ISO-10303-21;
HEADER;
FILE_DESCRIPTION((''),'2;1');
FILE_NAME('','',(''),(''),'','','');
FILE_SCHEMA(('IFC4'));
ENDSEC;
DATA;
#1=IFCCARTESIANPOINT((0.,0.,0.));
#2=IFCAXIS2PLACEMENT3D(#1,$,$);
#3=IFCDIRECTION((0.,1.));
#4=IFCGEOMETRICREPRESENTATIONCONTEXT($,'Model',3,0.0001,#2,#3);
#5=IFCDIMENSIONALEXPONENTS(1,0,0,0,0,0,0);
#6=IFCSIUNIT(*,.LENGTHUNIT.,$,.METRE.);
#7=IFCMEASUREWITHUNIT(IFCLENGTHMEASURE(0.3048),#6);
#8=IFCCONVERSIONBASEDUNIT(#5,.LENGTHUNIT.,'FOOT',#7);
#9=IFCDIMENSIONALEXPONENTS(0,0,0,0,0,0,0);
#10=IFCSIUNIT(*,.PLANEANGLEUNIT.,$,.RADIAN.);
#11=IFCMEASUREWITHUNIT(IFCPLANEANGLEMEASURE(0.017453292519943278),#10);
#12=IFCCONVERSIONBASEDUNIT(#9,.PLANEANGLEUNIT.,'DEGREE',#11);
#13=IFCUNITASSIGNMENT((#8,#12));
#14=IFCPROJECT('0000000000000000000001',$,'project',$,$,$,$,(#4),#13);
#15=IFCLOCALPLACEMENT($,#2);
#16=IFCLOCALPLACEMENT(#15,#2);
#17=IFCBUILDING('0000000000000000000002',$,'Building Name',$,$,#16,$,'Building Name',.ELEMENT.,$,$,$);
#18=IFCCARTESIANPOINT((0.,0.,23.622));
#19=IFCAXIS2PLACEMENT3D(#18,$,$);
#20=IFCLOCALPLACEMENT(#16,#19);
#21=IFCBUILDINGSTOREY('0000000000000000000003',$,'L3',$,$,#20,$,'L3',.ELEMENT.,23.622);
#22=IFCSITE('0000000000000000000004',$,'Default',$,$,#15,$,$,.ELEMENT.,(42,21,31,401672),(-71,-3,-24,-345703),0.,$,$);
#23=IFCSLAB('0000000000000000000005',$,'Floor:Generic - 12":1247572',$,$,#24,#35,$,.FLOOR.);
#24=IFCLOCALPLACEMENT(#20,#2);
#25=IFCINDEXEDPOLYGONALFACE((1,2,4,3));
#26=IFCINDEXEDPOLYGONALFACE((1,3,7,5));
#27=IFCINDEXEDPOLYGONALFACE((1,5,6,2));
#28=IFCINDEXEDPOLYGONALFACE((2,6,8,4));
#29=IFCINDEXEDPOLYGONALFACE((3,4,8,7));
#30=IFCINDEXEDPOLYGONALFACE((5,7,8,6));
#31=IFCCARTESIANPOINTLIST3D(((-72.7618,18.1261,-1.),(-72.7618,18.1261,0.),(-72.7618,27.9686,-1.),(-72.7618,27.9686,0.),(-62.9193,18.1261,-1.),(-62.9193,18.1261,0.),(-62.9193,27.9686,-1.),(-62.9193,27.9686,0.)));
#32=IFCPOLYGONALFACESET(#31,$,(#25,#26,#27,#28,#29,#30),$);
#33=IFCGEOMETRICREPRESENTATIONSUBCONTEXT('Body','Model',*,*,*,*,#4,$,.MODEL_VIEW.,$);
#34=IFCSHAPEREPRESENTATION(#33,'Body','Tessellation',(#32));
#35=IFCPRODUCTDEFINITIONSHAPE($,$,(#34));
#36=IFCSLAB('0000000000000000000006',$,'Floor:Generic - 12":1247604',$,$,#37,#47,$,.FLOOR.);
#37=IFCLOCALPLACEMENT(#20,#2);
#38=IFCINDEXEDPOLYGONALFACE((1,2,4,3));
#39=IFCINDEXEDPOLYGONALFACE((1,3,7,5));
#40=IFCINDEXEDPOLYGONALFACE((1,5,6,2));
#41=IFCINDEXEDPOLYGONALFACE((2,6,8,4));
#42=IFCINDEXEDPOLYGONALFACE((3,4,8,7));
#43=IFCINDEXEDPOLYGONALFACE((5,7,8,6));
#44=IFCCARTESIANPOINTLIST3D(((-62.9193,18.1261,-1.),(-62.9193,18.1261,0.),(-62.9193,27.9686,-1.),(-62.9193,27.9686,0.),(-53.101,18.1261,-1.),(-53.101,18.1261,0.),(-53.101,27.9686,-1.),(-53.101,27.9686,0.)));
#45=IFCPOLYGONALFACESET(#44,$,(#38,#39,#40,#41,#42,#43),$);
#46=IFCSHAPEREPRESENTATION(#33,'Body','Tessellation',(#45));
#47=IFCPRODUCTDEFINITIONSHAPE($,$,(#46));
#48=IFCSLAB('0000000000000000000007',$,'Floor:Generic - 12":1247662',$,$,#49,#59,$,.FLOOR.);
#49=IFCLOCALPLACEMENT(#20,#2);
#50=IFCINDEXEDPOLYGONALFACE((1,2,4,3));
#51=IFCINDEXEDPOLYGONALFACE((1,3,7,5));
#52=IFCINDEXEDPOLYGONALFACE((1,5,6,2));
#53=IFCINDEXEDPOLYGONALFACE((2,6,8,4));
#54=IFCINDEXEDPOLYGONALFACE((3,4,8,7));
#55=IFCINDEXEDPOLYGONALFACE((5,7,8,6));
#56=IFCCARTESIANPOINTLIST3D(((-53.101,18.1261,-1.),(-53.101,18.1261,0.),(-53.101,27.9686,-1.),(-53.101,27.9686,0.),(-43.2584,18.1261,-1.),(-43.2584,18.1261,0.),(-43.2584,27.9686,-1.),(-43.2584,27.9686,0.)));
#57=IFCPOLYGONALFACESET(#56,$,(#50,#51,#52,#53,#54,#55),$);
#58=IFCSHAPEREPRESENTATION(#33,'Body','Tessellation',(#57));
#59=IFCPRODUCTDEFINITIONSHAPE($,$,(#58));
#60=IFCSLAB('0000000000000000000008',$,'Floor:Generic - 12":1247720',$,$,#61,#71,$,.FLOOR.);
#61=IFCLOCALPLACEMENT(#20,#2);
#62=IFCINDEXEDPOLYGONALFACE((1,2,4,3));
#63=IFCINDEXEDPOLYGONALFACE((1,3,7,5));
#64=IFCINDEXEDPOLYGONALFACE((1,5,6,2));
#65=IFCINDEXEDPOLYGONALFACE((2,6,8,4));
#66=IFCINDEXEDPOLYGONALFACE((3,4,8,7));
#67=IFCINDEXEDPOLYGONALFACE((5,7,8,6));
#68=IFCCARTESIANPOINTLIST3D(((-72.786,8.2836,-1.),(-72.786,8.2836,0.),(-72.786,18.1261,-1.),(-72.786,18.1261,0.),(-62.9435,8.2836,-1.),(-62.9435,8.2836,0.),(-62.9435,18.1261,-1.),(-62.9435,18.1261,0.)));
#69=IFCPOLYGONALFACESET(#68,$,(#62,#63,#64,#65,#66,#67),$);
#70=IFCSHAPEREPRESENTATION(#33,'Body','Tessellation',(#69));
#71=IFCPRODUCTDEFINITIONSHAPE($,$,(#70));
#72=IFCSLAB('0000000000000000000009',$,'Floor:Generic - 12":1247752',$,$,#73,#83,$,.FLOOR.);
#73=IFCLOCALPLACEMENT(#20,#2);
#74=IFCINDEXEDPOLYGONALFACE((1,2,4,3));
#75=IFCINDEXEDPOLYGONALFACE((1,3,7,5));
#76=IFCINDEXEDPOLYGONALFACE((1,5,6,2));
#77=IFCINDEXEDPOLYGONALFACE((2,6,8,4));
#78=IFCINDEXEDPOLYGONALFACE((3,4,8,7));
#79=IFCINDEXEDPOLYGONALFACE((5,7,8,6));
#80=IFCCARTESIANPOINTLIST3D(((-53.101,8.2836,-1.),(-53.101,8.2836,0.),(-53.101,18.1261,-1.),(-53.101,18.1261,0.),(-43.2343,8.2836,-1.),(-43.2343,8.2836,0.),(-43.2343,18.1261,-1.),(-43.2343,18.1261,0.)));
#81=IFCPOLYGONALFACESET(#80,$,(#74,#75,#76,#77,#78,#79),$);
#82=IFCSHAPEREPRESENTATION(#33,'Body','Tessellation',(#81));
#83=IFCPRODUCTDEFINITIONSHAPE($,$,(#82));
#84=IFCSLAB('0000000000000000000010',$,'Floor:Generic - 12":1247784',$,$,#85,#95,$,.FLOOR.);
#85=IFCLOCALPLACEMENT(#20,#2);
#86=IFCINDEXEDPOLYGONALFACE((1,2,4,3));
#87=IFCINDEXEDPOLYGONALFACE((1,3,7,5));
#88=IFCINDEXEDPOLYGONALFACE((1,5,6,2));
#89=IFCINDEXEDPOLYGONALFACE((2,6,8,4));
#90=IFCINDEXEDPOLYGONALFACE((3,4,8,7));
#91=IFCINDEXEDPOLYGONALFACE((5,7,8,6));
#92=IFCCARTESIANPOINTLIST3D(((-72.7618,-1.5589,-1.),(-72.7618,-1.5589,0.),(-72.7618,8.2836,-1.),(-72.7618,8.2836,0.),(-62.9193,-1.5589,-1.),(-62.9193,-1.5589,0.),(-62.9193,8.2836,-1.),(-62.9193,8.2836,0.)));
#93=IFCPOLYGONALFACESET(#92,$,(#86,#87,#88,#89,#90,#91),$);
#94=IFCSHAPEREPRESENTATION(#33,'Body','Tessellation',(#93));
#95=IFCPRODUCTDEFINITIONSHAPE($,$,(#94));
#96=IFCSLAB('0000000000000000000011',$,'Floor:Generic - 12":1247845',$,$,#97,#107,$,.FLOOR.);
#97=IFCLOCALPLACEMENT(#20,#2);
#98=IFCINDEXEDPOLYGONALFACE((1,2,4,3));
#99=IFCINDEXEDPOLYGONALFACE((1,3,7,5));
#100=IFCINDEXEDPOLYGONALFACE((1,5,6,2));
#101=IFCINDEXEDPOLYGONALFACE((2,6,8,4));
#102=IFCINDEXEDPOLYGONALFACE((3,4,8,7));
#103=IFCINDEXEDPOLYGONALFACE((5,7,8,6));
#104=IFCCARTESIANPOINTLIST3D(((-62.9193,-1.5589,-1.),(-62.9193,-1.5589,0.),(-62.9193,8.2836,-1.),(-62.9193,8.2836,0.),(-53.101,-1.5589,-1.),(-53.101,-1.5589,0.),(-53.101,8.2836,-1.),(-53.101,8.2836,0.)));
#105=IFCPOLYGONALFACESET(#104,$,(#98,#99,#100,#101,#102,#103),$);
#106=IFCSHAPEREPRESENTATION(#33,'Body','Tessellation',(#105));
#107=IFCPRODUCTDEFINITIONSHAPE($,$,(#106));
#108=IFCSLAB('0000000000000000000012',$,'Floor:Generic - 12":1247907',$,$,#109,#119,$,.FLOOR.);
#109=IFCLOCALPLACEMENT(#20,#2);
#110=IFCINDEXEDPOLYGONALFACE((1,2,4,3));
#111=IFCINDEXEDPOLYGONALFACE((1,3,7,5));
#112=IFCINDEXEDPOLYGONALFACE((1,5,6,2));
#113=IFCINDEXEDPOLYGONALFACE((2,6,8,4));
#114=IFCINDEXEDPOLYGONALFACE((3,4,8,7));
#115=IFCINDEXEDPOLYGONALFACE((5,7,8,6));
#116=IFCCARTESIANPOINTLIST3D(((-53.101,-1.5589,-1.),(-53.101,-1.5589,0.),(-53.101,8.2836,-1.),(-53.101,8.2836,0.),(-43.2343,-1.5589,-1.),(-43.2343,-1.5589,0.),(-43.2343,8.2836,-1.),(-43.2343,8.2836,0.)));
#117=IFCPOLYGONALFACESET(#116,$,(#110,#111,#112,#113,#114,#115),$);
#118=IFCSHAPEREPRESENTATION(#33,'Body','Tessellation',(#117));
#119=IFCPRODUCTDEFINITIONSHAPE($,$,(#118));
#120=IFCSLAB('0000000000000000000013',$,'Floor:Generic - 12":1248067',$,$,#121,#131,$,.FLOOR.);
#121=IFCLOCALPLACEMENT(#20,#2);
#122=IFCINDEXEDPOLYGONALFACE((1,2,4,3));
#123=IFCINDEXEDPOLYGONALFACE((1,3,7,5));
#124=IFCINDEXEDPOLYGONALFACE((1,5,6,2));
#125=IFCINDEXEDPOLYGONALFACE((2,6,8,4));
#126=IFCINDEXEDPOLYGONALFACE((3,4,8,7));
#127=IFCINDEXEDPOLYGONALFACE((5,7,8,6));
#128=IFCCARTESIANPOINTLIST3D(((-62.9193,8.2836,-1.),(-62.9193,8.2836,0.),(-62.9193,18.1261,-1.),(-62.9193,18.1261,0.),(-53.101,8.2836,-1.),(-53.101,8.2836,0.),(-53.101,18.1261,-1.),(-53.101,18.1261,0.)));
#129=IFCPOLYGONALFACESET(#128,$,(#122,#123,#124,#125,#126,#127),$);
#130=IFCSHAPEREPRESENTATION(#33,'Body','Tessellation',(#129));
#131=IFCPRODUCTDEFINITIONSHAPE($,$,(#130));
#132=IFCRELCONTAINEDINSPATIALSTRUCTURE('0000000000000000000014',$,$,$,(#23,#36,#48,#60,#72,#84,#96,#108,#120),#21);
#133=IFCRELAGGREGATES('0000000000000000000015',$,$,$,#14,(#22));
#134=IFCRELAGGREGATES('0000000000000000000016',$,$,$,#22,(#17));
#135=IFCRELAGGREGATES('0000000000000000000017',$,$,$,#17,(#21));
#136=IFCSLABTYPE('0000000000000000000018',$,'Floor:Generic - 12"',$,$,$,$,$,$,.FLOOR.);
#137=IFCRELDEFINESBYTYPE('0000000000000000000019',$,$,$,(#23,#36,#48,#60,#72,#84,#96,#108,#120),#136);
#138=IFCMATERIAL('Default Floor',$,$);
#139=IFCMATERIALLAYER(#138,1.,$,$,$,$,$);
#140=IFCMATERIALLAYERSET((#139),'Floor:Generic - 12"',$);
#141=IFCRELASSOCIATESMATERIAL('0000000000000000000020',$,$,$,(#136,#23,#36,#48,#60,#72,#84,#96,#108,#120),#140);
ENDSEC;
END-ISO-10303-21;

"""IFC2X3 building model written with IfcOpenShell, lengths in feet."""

from ifc_helpers import new_model, entity, si_unit, converted_unit, direction, frame, frame_2d, origin, origin_2d_with_axis, place, context, subcontext, project, spatial, rectangle, extrude, material, layer, layer_set, layer_usage, type_object, element, save


model = new_model("IFC2X3")

# Units and contexts
model_context = context("Model", 3, precision=0.0001, world=origin(), true_north=direction((0.0, 1.0)))
body_context = subcontext(model_context, "Body", "Model", "MODEL_VIEW")
ifc_project = project(units=[converted_unit("LENGTHUNIT", "FOOT", entity("IfcLengthMeasure", 0.3048), si_unit("LENGTHUNIT", "METRE"), dimensions=[1, 0, 0, 0, 0, 0, 0]), converted_unit("PLANEANGLEUNIT", "DEGREE", entity("IfcPlaneAngleMeasure", 0.017453292519943278), si_unit("PLANEANGLEUNIT", "RADIAN"), dimensions=[0, 0, 0, 0, 0, 0, 0])], contexts=[model_context])

# Site, building, storey
site_placement = place(None, origin())
site = spatial("IfcSite", under=ifc_project, at=site_placement, Name="Default", CompositionType="ELEMENT", RefLatitude=(42, 21, 31, 401672), RefLongitude=(-71, -3, -24, -345703), RefElevation=0.0)
building_placement = place(site_placement, origin())
building = spatial("IfcBuilding", under=site, at=building_placement, Name="Building Name", LongName="Building Name", CompositionType="ELEMENT")
storey_placement = place(building_placement, frame((0.0, 0.0, 23.622)))
storey = spatial("IfcBuildingStorey", under=building, at=storey_placement, Name="L3", LongName="L3", CompositionType="ELEMENT", Elevation=23.622)

# Slabs
ifc_material = material(Name="Default Floor")
ifc_layer = layer(ifc_material, 1.0)
ifc_layer_set = layer_set([ifc_layer], Name="Floor:Generic - 12\"")
ifc_layer_usage_1 = layer_usage(ifc_layer_set, "AXIS3", "POSITIVE", 0.0)
slab_type = type_object("IfcSlabType", Name="Floor:Generic - 12\"", PredefinedType="FLOOR", material=ifc_layer_set)
slab_1_placement = place(storey_placement, origin())
element("IfcSlab", 1, at=slab_1_placement, inside=storey, type_object=slab_type, material=ifc_layer_usage_1, Name="Floor:Generic - 12\":1247572", PredefinedType="FLOOR", context=body_context, shape_type="SweptSolid", body=[
    extrude(rectangle(XDim=9.8425, YDim=9.8425, at=origin_2d_with_axis()), frame((-67.8406, 23.0474, 0.0), z_axis=(0.0, 0.0, -1.0), x_axis=(0.0, 1.0, 0.0)), (0.0, 0.0, 1.0), 1.0),
])
ifc_layer_usage_2 = layer_usage(ifc_layer_set, "AXIS3", "POSITIVE", 0.0)
slab_2_placement = place(storey_placement, origin())
element("IfcSlab", 2, at=slab_2_placement, inside=storey, type_object=slab_type, material=ifc_layer_usage_2, Name="Floor:Generic - 12\":1247604", PredefinedType="FLOOR", context=body_context, shape_type="SweptSolid", body=[
    extrude(rectangle(XDim=9.8425, YDim=9.8184, at=frame_2d((0.0, 0.0), x_axis=(1.0, 0.0))), frame((-58.0101, 23.0474, 0.0), z_axis=(0.0, 0.0, -1.0), x_axis=(0.0, 1.0, 0.0)), (0.0, 0.0, 1.0), 1.0),
])
ifc_layer_usage_3 = layer_usage(ifc_layer_set, "AXIS3", "POSITIVE", 0.0)
slab_3_placement = place(storey_placement, origin())
element("IfcSlab", 3, at=slab_3_placement, inside=storey, type_object=slab_type, material=ifc_layer_usage_3, Name="Floor:Generic - 12\":1247662", PredefinedType="FLOOR", context=body_context, shape_type="SweptSolid", body=[
    extrude(rectangle(XDim=9.8425, YDim=9.8425, at=frame_2d((0.0, 0.0), x_axis=(1.0, 0.0))), frame((-48.1797, 23.0474, 0.0), z_axis=(0.0, 0.0, -1.0), x_axis=(0.0, 1.0, 0.0)), (0.0, 0.0, 1.0), 1.0),
])
ifc_layer_usage_4 = layer_usage(ifc_layer_set, "AXIS3", "POSITIVE", 0.0)
slab_4_placement = place(storey_placement, origin())
element("IfcSlab", 4, at=slab_4_placement, inside=storey, type_object=slab_type, material=ifc_layer_usage_4, Name="Floor:Generic - 12\":1247720", PredefinedType="FLOOR", context=body_context, shape_type="SweptSolid", body=[
    extrude(rectangle(XDim=9.8425, YDim=9.8425, at=frame_2d((0.0, 0.0), x_axis=(1.0, 0.0))), frame((-67.8647, 13.2049, 0.0), z_axis=(0.0, 0.0, -1.0), x_axis=(0.0, 1.0, 0.0)), (0.0, 0.0, 1.0), 1.0),
])
ifc_layer_usage_5 = layer_usage(ifc_layer_set, "AXIS3", "POSITIVE", 0.0)
slab_5_placement = place(storey_placement, origin())
element("IfcSlab", 5, at=slab_5_placement, inside=storey, type_object=slab_type, material=ifc_layer_usage_5, Name="Floor:Generic - 12\":1247752", PredefinedType="FLOOR", context=body_context, shape_type="SweptSolid", body=[
    extrude(rectangle(XDim=9.8425, YDim=9.8667, at=frame_2d((0.0, 0.0), x_axis=(1.0, 0.0))), frame((-48.1676, 13.2049, 0.0), z_axis=(0.0, 0.0, -1.0), x_axis=(0.0, 1.0, 0.0)), (0.0, 0.0, 1.0), 1.0),
])
ifc_layer_usage_6 = layer_usage(ifc_layer_set, "AXIS3", "POSITIVE", 0.0)
slab_6_placement = place(storey_placement, origin())
element("IfcSlab", 6, at=slab_6_placement, inside=storey, type_object=slab_type, material=ifc_layer_usage_6, Name="Floor:Generic - 12\":1247784", PredefinedType="FLOOR", context=body_context, shape_type="SweptSolid", body=[
    extrude(rectangle(XDim=9.8425, YDim=9.8425, at=origin_2d_with_axis()), frame((-67.8406, 3.3623, 0.0), z_axis=(0.0, 0.0, -1.0), x_axis=(0.0, 1.0, 0.0)), (0.0, 0.0, 1.0), 1.0),
])
ifc_layer_usage_7 = layer_usage(ifc_layer_set, "AXIS3", "POSITIVE", 0.0)
slab_7_placement = place(storey_placement, origin())
element("IfcSlab", 7, at=slab_7_placement, inside=storey, type_object=slab_type, material=ifc_layer_usage_7, Name="Floor:Generic - 12\":1247845", PredefinedType="FLOOR", context=body_context, shape_type="SweptSolid", body=[
    extrude(rectangle(XDim=9.8425, YDim=9.8184, at=origin_2d_with_axis()), frame((-58.0101, 3.3623, 0.0), z_axis=(0.0, 0.0, -1.0), x_axis=(0.0, 1.0, 0.0)), (0.0, 0.0, 1.0), 1.0),
])
ifc_layer_usage_8 = layer_usage(ifc_layer_set, "AXIS3", "POSITIVE", 0.0)
slab_8_placement = place(storey_placement, origin())
element("IfcSlab", 8, at=slab_8_placement, inside=storey, type_object=slab_type, material=ifc_layer_usage_8, Name="Floor:Generic - 12\":1247907", PredefinedType="FLOOR", context=body_context, shape_type="SweptSolid", body=[
    extrude(rectangle(XDim=9.8425, YDim=9.8667, at=frame_2d((0.0, 0.0), x_axis=(1.0, 0.0))), frame((-48.1676, 3.3623, 0.0), z_axis=(0.0, 0.0, -1.0), x_axis=(0.0, 1.0, 0.0)), (0.0, 0.0, 1.0), 1.0),
])
ifc_layer_usage_9 = layer_usage(ifc_layer_set, "AXIS3", "POSITIVE", 0.0)
slab_9_placement = place(storey_placement, origin())
element("IfcSlab", 9, at=slab_9_placement, inside=storey, type_object=slab_type, material=ifc_layer_usage_9, Name="Floor:Generic - 12\":1248067", PredefinedType="FLOOR", context=body_context, shape_type="SweptSolid", body=[
    extrude(rectangle(XDim=9.8425, YDim=9.8184, at=frame_2d((0.0, 0.0), x_axis=(1.0, 0.0))), frame((-58.0101, 13.2049, 0.0), z_axis=(0.0, 0.0, -1.0), x_axis=(0.0, 1.0, 0.0)), (0.0, 0.0, 1.0), 1.0),
])

save(model, "model.ifc")
